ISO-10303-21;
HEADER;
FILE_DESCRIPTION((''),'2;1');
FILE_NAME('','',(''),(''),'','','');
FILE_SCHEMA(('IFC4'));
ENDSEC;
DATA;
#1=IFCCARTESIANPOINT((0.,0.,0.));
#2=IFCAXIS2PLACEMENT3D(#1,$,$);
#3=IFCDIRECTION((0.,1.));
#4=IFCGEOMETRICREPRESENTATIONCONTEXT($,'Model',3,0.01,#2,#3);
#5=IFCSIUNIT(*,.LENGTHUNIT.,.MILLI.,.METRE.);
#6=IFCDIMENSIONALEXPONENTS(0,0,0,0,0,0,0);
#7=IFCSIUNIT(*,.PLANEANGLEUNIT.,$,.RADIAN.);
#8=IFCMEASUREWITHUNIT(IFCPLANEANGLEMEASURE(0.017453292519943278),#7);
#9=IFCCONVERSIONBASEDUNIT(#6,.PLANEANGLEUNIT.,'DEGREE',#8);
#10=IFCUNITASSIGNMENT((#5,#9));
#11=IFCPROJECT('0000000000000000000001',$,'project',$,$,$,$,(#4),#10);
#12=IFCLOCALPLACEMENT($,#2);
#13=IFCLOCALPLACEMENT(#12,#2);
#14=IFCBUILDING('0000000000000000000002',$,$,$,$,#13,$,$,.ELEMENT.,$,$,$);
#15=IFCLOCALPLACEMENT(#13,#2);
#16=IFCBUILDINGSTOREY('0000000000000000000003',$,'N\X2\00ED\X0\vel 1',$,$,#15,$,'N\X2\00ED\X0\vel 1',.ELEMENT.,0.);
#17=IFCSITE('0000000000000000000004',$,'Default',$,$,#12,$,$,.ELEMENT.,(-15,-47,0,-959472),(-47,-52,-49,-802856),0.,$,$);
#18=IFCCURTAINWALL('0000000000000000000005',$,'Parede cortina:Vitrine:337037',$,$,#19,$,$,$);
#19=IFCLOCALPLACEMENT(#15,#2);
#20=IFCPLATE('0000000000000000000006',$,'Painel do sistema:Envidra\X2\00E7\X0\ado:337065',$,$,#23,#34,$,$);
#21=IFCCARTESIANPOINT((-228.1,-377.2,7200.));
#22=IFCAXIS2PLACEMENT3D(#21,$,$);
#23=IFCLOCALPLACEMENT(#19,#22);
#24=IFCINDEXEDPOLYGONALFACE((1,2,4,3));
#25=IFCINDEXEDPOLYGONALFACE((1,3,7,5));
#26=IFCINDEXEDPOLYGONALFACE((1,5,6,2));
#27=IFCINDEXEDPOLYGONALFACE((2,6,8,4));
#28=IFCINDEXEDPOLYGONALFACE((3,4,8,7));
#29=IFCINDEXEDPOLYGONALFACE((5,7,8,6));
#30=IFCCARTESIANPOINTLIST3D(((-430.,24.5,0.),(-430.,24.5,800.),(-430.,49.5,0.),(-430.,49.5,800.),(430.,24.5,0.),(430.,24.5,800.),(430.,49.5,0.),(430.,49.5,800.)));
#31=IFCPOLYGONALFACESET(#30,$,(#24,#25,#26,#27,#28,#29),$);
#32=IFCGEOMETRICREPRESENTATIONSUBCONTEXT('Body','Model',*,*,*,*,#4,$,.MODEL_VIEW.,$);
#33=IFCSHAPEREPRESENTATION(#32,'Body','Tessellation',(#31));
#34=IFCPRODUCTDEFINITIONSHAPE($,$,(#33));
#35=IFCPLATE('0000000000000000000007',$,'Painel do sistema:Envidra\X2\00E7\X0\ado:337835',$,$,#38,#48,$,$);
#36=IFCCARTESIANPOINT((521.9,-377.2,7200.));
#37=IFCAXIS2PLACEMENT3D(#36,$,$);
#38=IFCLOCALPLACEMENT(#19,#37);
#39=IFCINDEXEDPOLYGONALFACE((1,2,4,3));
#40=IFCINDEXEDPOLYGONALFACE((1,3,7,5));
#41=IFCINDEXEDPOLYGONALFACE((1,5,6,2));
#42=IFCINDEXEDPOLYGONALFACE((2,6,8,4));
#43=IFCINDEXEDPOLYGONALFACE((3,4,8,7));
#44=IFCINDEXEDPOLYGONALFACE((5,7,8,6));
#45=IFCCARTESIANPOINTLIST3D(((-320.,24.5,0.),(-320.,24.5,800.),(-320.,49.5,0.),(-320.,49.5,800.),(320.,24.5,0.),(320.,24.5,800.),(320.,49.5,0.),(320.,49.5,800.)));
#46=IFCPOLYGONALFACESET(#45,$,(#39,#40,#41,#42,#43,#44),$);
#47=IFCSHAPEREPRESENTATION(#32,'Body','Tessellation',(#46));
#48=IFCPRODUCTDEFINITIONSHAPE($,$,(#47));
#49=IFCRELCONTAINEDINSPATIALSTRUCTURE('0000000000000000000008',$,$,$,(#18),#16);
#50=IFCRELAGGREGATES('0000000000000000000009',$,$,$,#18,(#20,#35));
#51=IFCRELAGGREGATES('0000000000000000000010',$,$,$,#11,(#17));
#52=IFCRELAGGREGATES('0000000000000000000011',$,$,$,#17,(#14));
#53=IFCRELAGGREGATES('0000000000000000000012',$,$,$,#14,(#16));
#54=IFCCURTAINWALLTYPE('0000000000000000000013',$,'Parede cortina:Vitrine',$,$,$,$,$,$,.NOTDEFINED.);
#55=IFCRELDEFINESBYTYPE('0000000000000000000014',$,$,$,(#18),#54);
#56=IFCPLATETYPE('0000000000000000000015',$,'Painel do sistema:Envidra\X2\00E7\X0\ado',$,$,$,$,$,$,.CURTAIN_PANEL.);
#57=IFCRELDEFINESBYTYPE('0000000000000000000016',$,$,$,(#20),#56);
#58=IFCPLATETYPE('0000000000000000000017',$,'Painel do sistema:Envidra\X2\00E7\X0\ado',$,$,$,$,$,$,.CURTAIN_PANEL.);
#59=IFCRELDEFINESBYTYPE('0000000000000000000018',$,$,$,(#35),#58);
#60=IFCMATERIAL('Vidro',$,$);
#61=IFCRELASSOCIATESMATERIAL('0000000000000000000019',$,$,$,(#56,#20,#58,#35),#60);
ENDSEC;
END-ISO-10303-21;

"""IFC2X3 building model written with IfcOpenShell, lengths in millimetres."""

from ifc_helpers import new_model, entity, si_unit, converted_unit, direction, frame, origin, origin_2d_with_axis, place, context, subcontext, project, spatial, rectangle, extrude, source, transform, mapped, material, type_object, type_shapes, element, aggregate, save


model = new_model("IFC2X3")

# Units and contexts
model_context = context("Model", 3, precision=0.01, world=origin(), true_north=direction((0.0, 1.0)))
body_context = subcontext(model_context, "Body", "Model", "MODEL_VIEW")
ifc_project = project(units=[si_unit("LENGTHUNIT", "METRE", prefix="MILLI"), converted_unit("PLANEANGLEUNIT", "DEGREE", entity("IfcPlaneAngleMeasure", 0.017453292519943278), si_unit("PLANEANGLEUNIT", "RADIAN"), dimensions=[0, 0, 0, 0, 0, 0, 0])], contexts=[model_context])

# Site, building, storey
site_placement = place(None, origin())
site = spatial("IfcSite", under=ifc_project, at=site_placement, Name="Default", CompositionType="ELEMENT", RefLatitude=(-15, -47, 0, -959472), RefLongitude=(-47, -52, -49, -802856), RefElevation=0.0)
building_placement = place(site_placement, origin())
building = spatial("IfcBuilding", under=site, at=building_placement, CompositionType="ELEMENT")
storey_placement = place(building_placement, origin())
storey = spatial("IfcBuildingStorey", under=building, at=storey_placement, Name="Nível 1", LongName="Nível 1", CompositionType="ELEMENT", Elevation=0.0)

# Curtain wall, plates
curtain_wall_type = type_object("IfcCurtainWallType", Name="Parede cortina:Vitrine", PredefinedType="NOTDEFINED")
curtain_wall_placement = place(storey_placement, origin())
curtain_wall = element("IfcCurtainWall", 1, at=curtain_wall_placement, inside=storey, type_object=curtain_wall_type, Name="Parede cortina:Vitrine:337037")
ifc_material_1 = material(Name="Vidro")
plate_type_1 = type_object("IfcPlateType", Name="Painel do sistema:Envidraçado", PredefinedType="CURTAIN_PANEL", material=ifc_material_1)
shared_shape_1 = source(origin(), body_context, "Body", "SweptSolid", [
    extrude(rectangle(XDim=25.0, YDim=860.0, at=origin_2d_with_axis()), frame((0.0, 37.0, 0.0), z_axis=(0.0, 0.0, 1.0), x_axis=(0.0, 1.0, 0.0)), (0.0, 0.0, 1.0), 800.0),
])
type_shapes(plate_type_1, [shared_shape_1])
plate_1_placement = place(curtain_wall_placement, frame((-228.1, -377.2, 7200.0)))
plate_1 = element("IfcPlate", 2, at=plate_1_placement, type_object=plate_type_1, material=ifc_material_1, Name="Painel do sistema:Envidraçado:337065", context=body_context, shape_type="MappedRepresentation", body=[
    mapped(shared_shape_1, transform((0.0, 0.0, 0.0), scale=1.0)),
])
plate_type_2 = type_object("IfcPlateType", Name="Painel do sistema:Envidraçado", PredefinedType="CURTAIN_PANEL", material=ifc_material_1)
shared_shape_2 = source(origin(), body_context, "Body", "SweptSolid", [
    extrude(rectangle(XDim=25.0, YDim=640.0, at=origin_2d_with_axis()), frame((0.0, 37.0, 0.0), z_axis=(0.0, 0.0, 1.0), x_axis=(0.0, 1.0, 0.0)), (0.0, 0.0, 1.0), 800.0),
])
type_shapes(plate_type_2, [shared_shape_2])
plate_2_placement = place(curtain_wall_placement, frame((521.9, -377.2, 7200.0)))
plate_2 = element("IfcPlate", 3, at=plate_2_placement, type_object=plate_type_2, material=ifc_material_1, Name="Painel do sistema:Envidraçado:337835", context=body_context, shape_type="MappedRepresentation", body=[
    mapped(shared_shape_2, transform((0.0, 0.0, 0.0), scale=1.0)),
])
aggregate(curtain_wall, [plate_1, plate_2])

save(model, "model.ifc")
